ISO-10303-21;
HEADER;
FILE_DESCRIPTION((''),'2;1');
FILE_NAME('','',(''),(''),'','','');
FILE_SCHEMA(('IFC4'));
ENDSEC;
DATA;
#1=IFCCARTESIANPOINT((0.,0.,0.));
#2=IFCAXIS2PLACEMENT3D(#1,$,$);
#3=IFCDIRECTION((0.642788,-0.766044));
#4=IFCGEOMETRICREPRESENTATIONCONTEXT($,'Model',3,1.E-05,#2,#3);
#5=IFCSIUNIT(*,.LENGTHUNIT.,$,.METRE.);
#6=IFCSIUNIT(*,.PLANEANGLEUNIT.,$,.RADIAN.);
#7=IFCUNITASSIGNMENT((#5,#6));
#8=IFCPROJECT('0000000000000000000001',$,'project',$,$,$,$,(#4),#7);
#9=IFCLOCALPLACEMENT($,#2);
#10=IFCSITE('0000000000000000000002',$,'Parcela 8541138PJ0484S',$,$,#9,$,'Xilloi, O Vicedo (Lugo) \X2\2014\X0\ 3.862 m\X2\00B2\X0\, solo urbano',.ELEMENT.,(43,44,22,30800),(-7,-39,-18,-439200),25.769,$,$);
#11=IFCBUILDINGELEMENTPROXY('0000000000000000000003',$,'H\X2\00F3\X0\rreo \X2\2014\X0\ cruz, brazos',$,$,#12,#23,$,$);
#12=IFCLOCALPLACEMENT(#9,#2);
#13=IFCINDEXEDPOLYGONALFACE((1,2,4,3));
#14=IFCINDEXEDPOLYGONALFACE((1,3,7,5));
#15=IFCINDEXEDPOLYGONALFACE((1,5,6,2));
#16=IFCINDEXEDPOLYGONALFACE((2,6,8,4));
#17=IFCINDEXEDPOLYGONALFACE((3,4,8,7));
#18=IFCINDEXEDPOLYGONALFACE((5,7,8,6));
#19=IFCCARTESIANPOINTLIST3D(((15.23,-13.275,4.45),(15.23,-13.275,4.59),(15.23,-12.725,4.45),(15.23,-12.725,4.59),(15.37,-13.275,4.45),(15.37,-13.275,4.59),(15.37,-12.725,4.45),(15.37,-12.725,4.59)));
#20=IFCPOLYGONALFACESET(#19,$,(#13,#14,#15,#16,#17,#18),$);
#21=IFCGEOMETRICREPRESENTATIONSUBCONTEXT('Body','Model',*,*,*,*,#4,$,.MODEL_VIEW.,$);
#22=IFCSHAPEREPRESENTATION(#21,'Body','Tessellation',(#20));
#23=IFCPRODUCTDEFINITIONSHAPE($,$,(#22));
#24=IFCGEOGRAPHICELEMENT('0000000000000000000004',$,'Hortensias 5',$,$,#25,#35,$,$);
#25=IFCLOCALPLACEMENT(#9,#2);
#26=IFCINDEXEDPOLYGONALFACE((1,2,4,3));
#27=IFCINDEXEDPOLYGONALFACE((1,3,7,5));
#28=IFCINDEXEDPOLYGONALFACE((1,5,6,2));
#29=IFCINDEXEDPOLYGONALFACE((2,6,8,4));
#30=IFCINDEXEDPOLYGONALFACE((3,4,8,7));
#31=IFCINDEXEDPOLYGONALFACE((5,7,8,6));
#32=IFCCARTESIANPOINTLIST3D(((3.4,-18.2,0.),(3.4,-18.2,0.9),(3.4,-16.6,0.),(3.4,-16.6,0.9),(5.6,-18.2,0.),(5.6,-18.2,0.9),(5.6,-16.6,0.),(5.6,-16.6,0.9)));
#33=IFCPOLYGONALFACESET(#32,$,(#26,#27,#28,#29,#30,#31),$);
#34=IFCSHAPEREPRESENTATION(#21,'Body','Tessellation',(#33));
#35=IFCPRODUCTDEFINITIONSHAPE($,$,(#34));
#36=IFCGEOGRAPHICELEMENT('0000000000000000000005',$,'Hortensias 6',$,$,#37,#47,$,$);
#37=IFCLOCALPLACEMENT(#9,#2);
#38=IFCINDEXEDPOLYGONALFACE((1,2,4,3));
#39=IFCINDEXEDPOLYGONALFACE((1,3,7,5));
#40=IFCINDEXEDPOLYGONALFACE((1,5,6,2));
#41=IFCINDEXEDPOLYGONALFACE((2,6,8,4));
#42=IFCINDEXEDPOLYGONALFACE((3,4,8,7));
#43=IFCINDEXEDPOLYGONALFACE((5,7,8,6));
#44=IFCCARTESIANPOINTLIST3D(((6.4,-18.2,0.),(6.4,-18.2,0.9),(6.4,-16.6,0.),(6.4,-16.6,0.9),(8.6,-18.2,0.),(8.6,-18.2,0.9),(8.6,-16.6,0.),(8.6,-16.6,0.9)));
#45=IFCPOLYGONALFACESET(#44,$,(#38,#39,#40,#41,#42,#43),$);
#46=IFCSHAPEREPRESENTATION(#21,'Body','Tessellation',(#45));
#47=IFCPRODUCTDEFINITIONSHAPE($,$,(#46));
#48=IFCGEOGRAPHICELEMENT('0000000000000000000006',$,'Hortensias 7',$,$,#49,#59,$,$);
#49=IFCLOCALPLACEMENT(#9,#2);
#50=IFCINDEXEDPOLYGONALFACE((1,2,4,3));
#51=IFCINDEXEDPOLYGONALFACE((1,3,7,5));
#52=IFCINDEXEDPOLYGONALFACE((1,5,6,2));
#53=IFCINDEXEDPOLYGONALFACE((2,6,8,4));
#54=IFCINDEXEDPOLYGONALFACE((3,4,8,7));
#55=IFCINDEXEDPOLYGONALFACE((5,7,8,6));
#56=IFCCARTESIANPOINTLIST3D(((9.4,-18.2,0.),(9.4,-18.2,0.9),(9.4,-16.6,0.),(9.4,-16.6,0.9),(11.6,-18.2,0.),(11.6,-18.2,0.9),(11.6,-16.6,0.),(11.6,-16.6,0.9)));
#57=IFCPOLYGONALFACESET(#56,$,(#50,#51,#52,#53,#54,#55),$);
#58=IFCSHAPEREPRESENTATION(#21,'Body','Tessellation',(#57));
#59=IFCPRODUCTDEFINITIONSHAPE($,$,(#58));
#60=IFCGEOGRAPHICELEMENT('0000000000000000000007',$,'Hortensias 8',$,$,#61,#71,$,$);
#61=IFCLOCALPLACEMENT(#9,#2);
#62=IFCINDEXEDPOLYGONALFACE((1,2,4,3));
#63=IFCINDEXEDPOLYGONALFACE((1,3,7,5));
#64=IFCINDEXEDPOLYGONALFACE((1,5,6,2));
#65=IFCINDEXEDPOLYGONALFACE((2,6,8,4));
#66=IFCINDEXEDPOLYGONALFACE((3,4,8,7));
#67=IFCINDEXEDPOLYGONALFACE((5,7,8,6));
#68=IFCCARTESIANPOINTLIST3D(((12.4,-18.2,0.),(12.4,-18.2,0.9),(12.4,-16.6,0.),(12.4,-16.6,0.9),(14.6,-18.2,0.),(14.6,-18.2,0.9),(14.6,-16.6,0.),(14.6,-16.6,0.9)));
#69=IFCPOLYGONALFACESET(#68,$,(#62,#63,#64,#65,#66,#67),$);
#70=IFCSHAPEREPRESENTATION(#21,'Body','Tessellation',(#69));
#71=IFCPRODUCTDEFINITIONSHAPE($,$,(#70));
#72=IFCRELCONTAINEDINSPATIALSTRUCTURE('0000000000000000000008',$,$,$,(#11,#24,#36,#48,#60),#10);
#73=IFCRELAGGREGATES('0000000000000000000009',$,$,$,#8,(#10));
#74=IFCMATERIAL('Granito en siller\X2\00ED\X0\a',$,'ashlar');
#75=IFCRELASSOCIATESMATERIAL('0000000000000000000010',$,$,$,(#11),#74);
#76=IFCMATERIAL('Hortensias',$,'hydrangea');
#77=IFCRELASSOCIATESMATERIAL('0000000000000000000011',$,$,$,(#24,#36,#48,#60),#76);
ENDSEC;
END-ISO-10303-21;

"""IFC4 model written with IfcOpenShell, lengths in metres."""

from ifc_helpers import new_model, si_unit, direction, frame, origin, origin_2d, place, context, subcontext, project, spatial, rectangle, extrude, material, element, save


model = new_model("IFC4")

# Units and contexts
model_context = context("Model", 3, precision=1e-05, world=origin(), true_north=direction((0.642788, -0.766044)))
body_context = subcontext(model_context, "Body", "Model", "MODEL_VIEW")
ifc_project = project(units=[si_unit("LENGTHUNIT", "METRE"), si_unit("PLANEANGLEUNIT", "RADIAN")], contexts=[model_context])

# Site
site_placement = place(None, origin())
site = spatial("IfcSite", under=ifc_project, at=site_placement, Name="Parcela 8541138PJ0484S", LongName="Xilloi, O Vicedo (Lugo) — 3.862 m², solo urbano", CompositionType="ELEMENT", RefLatitude=(43, 44, 22, 30800), RefLongitude=(-7, -39, -18, -439200), RefElevation=25.769)

# Shared definitions
ifc_material_1 = material(Name="Granito en sillería", Category="ashlar")

# Building element proxy
proxy_1_placement = place(site_placement, frame((15.3, -13.0, 4.52)))
element("IfcBuildingElementProxy", 1, at=proxy_1_placement, inside=site, material=ifc_material_1, Name="Hórreo — cruz, brazos", context=body_context, shape_type="SweptSolid", body=[
    extrude(rectangle(XDim=0.14, YDim=0.55, at=origin_2d()), frame((0.0, 0.0, -0.07)), (0.0, 0.0, 1.0), 0.14),
])

# Geographic elements
ifc_material_2 = material(Name="Hortensias", Category="hydrangea")
for number, where, name in (
    (2, (4.5, -17.4, 0.45), "Hortensias 5"),
    (3, (7.5, -17.4, 0.45), "Hortensias 6"),
    (4, (10.5, -17.4, 0.45), "Hortensias 7"),
    (5, (13.5, -17.4, 0.45), "Hortensias 8"),
):
    element("IfcGeographicElement", number, at=place(site_placement, frame(where)), inside=site, material=ifc_material_2, Name=name, context=body_context, shape_type="SweptSolid", body=[
        extrude(rectangle(XDim=2.2, YDim=1.6, at=origin_2d()), frame((0.0, 0.0, -0.45)), (0.0, 0.0, 1.0), 0.9),
    ])

save(model, "model.ifc")
